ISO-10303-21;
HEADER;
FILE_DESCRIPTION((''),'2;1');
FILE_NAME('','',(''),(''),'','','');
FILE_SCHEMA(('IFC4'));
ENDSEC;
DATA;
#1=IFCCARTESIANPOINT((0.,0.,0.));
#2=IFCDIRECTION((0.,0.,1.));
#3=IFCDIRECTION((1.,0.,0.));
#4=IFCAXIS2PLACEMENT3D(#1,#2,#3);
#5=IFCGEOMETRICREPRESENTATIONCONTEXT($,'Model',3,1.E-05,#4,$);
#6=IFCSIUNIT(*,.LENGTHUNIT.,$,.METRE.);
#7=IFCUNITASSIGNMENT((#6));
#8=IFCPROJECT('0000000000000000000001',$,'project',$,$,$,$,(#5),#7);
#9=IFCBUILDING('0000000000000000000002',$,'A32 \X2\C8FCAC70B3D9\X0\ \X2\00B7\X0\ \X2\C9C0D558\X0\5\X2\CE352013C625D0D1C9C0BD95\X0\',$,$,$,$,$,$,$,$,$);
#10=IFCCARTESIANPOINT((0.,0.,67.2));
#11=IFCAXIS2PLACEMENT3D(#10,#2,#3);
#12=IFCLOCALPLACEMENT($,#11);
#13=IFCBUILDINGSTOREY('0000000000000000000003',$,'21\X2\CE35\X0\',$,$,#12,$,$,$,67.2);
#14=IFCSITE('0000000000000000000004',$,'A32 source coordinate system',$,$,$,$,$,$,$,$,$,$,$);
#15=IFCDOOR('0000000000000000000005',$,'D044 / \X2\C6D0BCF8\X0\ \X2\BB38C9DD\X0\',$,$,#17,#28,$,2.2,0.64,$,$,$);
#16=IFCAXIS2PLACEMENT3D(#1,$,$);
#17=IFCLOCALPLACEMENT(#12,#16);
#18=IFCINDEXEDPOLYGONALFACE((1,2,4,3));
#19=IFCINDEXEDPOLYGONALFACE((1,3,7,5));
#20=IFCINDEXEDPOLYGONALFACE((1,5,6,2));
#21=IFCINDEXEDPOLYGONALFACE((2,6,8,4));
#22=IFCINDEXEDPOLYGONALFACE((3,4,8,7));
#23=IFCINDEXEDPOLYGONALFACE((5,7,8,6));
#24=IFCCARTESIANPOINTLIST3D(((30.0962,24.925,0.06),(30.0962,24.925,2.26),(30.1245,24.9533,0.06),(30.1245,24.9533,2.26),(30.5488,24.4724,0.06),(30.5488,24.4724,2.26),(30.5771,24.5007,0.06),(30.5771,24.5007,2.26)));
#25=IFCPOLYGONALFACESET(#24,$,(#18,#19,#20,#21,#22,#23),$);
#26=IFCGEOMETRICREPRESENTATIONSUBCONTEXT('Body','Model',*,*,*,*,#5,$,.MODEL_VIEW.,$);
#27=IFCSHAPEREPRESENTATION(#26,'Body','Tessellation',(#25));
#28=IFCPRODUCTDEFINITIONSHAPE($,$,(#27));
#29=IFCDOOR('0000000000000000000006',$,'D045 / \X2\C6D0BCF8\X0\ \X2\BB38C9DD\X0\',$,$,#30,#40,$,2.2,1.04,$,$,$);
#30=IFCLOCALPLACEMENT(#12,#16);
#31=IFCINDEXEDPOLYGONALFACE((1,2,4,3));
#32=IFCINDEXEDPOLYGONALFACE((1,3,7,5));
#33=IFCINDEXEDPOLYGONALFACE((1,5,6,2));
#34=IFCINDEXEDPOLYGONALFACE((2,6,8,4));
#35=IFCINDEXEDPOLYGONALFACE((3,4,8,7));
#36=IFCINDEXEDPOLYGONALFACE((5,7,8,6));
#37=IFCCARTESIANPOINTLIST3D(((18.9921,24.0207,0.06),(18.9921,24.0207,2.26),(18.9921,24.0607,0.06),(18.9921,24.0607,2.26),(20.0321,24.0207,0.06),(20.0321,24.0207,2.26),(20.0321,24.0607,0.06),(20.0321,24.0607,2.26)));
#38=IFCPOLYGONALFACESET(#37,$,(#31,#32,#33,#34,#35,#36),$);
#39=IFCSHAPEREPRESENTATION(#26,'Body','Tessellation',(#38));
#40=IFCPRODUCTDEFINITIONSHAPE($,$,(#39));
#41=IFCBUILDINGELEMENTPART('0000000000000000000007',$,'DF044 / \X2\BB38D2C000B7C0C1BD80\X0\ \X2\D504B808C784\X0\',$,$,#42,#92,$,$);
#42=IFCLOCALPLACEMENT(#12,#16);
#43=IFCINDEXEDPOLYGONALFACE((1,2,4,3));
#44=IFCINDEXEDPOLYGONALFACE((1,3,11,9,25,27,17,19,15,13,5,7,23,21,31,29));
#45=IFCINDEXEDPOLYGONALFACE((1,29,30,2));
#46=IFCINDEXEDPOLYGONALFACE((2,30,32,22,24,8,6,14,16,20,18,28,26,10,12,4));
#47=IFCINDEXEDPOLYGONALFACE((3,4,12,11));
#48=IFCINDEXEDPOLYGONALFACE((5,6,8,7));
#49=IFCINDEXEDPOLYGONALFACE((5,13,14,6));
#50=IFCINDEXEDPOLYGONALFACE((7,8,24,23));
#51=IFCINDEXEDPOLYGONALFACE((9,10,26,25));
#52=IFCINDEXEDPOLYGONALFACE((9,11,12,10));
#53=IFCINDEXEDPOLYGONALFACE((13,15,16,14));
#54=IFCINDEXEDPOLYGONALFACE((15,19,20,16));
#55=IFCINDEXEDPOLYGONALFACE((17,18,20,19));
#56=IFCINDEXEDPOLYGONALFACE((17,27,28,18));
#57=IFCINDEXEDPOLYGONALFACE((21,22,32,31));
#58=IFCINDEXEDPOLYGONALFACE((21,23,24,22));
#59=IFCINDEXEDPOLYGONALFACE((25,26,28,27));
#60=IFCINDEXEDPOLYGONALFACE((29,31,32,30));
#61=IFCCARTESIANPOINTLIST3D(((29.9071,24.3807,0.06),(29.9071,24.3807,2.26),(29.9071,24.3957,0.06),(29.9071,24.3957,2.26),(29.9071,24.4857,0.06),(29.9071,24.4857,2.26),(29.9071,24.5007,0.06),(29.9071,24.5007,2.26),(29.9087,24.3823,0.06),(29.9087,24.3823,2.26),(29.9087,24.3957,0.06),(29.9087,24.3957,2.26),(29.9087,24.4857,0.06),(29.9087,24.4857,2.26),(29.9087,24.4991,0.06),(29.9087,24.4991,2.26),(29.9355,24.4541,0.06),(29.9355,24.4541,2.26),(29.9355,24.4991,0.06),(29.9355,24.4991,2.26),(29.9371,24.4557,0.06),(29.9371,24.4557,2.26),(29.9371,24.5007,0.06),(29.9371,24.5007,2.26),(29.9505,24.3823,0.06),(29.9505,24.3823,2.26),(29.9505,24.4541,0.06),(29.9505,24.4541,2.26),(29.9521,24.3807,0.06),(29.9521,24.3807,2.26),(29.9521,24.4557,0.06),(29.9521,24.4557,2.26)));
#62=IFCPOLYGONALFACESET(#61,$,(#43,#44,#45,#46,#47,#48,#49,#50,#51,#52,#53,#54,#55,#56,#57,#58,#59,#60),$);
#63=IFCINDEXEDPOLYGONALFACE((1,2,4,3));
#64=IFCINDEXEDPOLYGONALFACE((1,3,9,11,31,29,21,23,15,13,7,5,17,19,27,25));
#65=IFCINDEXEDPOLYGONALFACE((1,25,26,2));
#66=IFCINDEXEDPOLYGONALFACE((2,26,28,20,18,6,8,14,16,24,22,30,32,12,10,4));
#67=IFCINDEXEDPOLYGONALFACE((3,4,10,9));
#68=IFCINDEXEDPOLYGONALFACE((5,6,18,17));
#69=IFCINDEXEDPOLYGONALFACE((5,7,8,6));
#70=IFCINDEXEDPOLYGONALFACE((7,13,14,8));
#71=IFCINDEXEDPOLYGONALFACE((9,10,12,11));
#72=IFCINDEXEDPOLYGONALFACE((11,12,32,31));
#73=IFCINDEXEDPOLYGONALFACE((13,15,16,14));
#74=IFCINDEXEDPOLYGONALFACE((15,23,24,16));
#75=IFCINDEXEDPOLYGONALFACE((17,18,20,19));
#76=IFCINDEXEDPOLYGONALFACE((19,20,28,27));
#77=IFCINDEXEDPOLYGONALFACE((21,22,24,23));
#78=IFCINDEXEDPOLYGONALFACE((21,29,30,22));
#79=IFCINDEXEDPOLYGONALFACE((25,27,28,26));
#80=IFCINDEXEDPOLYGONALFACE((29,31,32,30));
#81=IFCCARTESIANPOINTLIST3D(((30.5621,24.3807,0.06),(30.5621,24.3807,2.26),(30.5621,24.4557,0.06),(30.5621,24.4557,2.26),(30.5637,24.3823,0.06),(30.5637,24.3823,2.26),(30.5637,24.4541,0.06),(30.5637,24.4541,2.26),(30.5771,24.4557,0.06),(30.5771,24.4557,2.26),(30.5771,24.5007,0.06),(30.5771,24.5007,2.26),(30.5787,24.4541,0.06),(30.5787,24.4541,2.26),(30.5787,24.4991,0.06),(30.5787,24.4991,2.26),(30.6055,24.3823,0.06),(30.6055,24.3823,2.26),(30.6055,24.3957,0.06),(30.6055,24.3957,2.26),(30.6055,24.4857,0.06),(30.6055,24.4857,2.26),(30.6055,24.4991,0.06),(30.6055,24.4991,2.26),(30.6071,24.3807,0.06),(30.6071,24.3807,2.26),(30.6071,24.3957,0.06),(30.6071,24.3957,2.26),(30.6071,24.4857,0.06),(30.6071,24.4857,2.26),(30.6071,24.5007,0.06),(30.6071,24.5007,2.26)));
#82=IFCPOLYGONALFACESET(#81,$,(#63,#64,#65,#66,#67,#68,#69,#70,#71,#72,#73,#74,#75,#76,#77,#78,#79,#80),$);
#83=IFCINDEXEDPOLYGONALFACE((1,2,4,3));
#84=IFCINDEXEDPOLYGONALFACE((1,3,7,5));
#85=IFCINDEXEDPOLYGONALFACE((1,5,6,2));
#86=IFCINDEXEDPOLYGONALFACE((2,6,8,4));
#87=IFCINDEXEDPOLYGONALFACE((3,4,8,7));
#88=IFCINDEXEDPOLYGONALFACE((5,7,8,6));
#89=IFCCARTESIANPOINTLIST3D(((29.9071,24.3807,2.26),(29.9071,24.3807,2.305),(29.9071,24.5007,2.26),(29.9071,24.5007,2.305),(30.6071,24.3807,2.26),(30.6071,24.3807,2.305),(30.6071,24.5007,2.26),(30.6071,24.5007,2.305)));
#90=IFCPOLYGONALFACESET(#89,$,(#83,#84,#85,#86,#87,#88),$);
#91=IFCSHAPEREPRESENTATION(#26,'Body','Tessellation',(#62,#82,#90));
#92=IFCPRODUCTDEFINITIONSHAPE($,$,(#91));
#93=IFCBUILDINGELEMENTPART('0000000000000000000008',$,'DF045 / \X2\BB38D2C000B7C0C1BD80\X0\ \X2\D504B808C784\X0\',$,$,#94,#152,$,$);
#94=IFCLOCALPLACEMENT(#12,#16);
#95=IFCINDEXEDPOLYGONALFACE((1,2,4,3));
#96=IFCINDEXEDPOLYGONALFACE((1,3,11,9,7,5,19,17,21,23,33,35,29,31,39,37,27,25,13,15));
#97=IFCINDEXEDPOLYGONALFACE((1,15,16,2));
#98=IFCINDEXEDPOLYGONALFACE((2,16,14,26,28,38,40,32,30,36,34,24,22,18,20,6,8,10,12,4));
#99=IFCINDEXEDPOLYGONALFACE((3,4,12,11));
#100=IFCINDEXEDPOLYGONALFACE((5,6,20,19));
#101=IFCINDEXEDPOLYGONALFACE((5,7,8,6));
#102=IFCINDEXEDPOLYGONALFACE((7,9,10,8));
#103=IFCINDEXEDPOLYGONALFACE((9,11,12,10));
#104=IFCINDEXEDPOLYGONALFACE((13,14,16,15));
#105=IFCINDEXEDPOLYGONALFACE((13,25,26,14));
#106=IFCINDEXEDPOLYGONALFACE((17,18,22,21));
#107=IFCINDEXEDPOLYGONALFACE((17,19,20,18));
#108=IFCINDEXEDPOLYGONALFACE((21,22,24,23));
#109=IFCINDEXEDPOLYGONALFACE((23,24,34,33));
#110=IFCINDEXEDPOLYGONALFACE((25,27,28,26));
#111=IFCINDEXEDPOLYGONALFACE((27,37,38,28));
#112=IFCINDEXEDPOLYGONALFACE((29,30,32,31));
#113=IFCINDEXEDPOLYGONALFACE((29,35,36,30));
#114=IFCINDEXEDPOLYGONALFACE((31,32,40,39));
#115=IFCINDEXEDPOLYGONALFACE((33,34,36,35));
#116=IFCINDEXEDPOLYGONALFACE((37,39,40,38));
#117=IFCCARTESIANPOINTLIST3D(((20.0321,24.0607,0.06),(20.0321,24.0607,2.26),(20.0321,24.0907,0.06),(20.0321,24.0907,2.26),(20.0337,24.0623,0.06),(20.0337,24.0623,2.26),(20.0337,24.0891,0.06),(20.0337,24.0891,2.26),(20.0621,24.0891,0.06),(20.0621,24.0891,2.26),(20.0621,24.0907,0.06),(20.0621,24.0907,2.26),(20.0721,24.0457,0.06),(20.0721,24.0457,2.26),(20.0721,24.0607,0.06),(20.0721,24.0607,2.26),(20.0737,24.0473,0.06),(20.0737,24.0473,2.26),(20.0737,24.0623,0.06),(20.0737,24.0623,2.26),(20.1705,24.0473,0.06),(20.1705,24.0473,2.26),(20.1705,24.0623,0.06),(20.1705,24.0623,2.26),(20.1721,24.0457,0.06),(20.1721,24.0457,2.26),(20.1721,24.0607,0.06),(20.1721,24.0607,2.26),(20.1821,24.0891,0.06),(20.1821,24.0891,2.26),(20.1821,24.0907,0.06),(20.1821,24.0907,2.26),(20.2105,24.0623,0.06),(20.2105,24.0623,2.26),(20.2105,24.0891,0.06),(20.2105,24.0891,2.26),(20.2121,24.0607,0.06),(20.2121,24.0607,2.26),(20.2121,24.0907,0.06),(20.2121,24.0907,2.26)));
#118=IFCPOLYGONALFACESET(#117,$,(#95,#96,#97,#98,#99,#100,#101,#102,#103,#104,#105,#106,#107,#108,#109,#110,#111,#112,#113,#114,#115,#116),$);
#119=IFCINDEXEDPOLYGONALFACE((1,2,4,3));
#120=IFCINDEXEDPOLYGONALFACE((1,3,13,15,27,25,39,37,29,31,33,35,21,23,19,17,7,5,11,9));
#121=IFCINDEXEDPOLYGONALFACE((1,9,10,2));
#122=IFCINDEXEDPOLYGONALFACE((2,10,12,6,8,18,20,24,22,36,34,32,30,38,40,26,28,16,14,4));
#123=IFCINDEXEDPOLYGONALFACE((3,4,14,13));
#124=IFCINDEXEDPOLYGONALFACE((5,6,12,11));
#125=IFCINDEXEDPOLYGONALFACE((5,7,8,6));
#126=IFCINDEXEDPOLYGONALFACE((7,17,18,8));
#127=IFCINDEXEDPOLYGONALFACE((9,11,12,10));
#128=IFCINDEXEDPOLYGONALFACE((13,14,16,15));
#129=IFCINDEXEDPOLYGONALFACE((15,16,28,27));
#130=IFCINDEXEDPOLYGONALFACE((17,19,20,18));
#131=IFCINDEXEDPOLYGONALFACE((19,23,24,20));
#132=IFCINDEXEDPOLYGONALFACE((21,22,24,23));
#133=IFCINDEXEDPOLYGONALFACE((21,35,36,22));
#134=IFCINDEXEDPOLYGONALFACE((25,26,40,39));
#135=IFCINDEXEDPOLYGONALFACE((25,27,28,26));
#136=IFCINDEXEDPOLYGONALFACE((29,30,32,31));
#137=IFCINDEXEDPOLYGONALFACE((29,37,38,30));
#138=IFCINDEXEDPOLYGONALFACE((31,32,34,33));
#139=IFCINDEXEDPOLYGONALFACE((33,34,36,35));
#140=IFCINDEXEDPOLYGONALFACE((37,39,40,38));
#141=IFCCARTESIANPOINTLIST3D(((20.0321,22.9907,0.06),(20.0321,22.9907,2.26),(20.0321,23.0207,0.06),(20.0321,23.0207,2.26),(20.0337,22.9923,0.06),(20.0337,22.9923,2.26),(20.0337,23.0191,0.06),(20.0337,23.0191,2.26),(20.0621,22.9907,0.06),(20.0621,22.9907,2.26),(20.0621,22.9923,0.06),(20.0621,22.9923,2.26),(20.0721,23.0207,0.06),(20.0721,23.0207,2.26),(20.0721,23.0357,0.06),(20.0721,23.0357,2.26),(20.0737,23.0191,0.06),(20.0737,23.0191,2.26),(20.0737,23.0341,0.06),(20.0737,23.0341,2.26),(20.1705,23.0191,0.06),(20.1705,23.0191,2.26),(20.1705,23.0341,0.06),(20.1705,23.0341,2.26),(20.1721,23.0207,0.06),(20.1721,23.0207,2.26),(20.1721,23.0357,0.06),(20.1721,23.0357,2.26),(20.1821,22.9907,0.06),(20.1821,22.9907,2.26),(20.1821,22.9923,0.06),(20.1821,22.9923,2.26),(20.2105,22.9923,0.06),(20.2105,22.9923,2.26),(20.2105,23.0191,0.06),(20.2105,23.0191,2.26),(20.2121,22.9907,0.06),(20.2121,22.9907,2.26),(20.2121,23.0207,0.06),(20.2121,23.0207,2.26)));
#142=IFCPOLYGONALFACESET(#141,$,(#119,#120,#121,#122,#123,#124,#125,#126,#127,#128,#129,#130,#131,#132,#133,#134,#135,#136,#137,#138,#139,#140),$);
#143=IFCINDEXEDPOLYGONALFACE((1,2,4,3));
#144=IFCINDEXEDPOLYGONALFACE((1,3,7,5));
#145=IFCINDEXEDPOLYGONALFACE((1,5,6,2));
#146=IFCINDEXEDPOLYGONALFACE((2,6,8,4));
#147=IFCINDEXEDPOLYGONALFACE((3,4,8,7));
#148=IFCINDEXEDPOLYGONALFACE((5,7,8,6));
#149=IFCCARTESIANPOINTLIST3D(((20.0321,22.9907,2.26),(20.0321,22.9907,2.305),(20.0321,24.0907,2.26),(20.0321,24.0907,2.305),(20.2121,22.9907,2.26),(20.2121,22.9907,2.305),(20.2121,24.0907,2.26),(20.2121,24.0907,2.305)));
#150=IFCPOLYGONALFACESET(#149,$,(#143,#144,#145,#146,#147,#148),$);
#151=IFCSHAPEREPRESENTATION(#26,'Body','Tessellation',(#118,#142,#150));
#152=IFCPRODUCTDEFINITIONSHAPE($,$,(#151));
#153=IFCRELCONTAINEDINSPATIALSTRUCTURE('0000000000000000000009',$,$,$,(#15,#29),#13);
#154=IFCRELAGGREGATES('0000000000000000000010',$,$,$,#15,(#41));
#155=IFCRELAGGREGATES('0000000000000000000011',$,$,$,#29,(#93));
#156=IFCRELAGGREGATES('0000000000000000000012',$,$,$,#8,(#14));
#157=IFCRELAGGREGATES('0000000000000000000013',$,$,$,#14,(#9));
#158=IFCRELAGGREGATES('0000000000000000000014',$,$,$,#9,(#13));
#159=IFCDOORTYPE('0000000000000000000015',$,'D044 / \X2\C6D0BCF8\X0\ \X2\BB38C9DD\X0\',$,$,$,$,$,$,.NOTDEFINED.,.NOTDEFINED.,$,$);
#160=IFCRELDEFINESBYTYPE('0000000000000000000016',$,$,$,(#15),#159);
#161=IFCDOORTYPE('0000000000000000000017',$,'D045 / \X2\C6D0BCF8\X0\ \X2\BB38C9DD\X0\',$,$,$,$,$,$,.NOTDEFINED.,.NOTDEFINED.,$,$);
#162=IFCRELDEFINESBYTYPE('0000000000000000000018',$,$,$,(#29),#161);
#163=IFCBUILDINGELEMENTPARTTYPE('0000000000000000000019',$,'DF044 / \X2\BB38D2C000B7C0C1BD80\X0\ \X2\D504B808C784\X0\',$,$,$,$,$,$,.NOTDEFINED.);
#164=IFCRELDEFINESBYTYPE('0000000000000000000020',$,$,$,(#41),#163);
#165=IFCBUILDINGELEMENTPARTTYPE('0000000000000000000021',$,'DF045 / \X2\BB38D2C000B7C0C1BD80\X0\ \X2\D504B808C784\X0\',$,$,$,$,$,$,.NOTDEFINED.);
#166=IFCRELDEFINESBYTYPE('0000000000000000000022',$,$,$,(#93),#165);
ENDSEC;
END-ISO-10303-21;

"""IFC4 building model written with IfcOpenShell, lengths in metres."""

from ifc_helpers import new_model, si_unit, frame, origin, origin_with_axes, place, context, subcontext, project, spatial, polyline, outline, extrude, source, transform, mapped, type_object, type_shapes, element, aggregate, save


model = new_model("IFC4")

# Units and contexts
model_context = context("Model", 3, precision=1e-05, world=origin_with_axes())
body_context = subcontext(model_context, "Body", "Model", "MODEL_VIEW")
ifc_project = project(units=[si_unit("LENGTHUNIT", "METRE")], contexts=[model_context])

# Site, building, storey
storey_placement = place(None, frame((0.0, 0.0, 67.2), z_axis=(0.0, 0.0, 1.0), x_axis=(1.0, 0.0, 0.0)))
site = spatial("IfcSite", under=ifc_project, Name="A32 source coordinate system")
building = spatial("IfcBuilding", under=site, Name="A32 주거동 · 지하5층–옥탑지붕")
storey = spatial("IfcBuildingStorey", under=building, at=storey_placement, Name="21층", Elevation=67.2)

# Doors
door_type_1 = type_object("IfcDoorType", Name="D044 / 원본 문짝", OperationType="NOTDEFINED", PredefinedType="NOTDEFINED")
shared_shape_1 = source(origin(), body_context, "Body", "SweptSolid", [
    extrude(outline(polyline([(30.5771, 24.5007), (30.5488, 24.4724), (30.0962, 24.925), (30.1245, 24.9533), (30.5771, 24.5007)])), frame((0.0, 0.0, 0.06)), (0.0, 0.0, 1.0), 2.2),
])
type_shapes(door_type_1, [shared_shape_1])
door_1_placement = place(storey_placement, origin_with_axes())
door_1 = element("IfcDoor", 1, at=door_1_placement, inside=storey, type_object=door_type_1, Name="D044 / 원본 문짝", OverallHeight=2.2, OverallWidth=0.64, context=body_context, shape_type="MappedRepresentation", body=[
    mapped(shared_shape_1, transform((0.0, 0.0, 0.0), scale=1.0)),
])
door_type_2 = type_object("IfcDoorType", Name="D045 / 원본 문짝", OperationType="NOTDEFINED", PredefinedType="NOTDEFINED")
shared_shape_2 = source(origin(), body_context, "Body", "SweptSolid", [
    extrude(outline(polyline([(20.0321, 24.0607), (20.0321, 24.0207), (18.9921, 24.0207), (18.9921, 24.0607), (20.0321, 24.0607)])), frame((0.0, 0.0, 0.06)), (0.0, 0.0, 1.0), 2.2),
])
type_shapes(door_type_2, [shared_shape_2])
door_2_placement = place(storey_placement, origin_with_axes())
door_2 = element("IfcDoor", 2, at=door_2_placement, inside=storey, type_object=door_type_2, Name="D045 / 원본 문짝", OverallHeight=2.2, OverallWidth=1.04, context=body_context, shape_type="MappedRepresentation", body=[
    mapped(shared_shape_2, transform((0.0, 0.0, 0.0), scale=1.0)),
])

# Building element parts
building_element_part_type_1 = type_object("IfcBuildingElementPartType", Name="DF044 / 문틀·상부 프레임", PredefinedType="NOTDEFINED")
shared_shape_3 = source(origin(), body_context, "Body", "SweptSolid", [
    extrude(outline(polyline([(29.9071, 24.4857), (29.9071, 24.5007), (29.9371, 24.5007), (29.9371, 24.4557), (29.9521, 24.4557), (29.9521, 24.3807), (29.9071, 24.3807), (29.9071, 24.3957), (29.9087, 24.3957), (29.9087, 24.3823), (29.9505, 24.3823), (29.9505, 24.4541), (29.9355, 24.4541), (29.9355, 24.4991), (29.9087, 24.4991), (29.9087, 24.4857), (29.9071, 24.4857)])), frame((0.0, 0.0, 0.06)), (0.0, 0.0, 1.0), 2.2),
    extrude(outline(polyline([(30.6055, 24.4991), (30.5787, 24.4991), (30.5787, 24.4541), (30.5637, 24.4541), (30.5637, 24.3823), (30.6055, 24.3823), (30.6055, 24.3957), (30.6071, 24.3957), (30.6071, 24.3807), (30.5621, 24.3807), (30.5621, 24.4557), (30.5771, 24.4557), (30.5771, 24.5007), (30.6071, 24.5007), (30.6071, 24.4857), (30.6055, 24.4857), (30.6055, 24.4991)])), frame((0.0, 0.0, 0.06)), (0.0, 0.0, 1.0), 2.2),
    extrude(outline(polyline([(29.9071, 24.3807), (29.9071, 24.5007), (30.6071, 24.5007), (30.6071, 24.3807), (29.9071, 24.3807)])), frame((0.0, 0.0, 2.26)), (0.0, 0.0, 1.0), 0.045),
])
type_shapes(building_element_part_type_1, [shared_shape_3])
building_element_part_1_placement = place(door_1_placement, origin_with_axes())
building_element_part_1 = element("IfcBuildingElementPart", 3, at=building_element_part_1_placement, type_object=building_element_part_type_1, Name="DF044 / 문틀·상부 프레임", context=body_context, shape_type="MappedRepresentation", body=[
    mapped(shared_shape_3, transform((0.0, 0.0, 0.0), scale=1.0)),
])
aggregate(door_1, [building_element_part_1])
building_element_part_type_2 = type_object("IfcBuildingElementPartType", Name="DF045 / 문틀·상부 프레임", PredefinedType="NOTDEFINED")
shared_shape_4 = source(origin(), body_context, "Body", "SweptSolid", [
    extrude(outline(polyline([(20.0337, 24.0891), (20.0337, 24.0623), (20.0737, 24.0623), (20.0737, 24.0473), (20.1705, 24.0473), (20.1705, 24.0623), (20.2105, 24.0623), (20.2105, 24.0891), (20.1821, 24.0891), (20.1821, 24.0907), (20.2121, 24.0907), (20.2121, 24.0607), (20.1721, 24.0607), (20.1721, 24.0457), (20.0721, 24.0457), (20.0721, 24.0607), (20.0321, 24.0607), (20.0321, 24.0907), (20.0621, 24.0907), (20.0621, 24.0891), (20.0337, 24.0891)])), frame((0.0, 0.0, 0.06)), (0.0, 0.0, 1.0), 2.2),
    extrude(outline(polyline([(20.0621, 22.9907), (20.0321, 22.9907), (20.0321, 23.0207), (20.0721, 23.0207), (20.0721, 23.0357), (20.1721, 23.0357), (20.1721, 23.0207), (20.2121, 23.0207), (20.2121, 22.9907), (20.1821, 22.9907), (20.1821, 22.9923), (20.2105, 22.9923), (20.2105, 23.0191), (20.1705, 23.0191), (20.1705, 23.0341), (20.0737, 23.0341), (20.0737, 23.0191), (20.0337, 23.0191), (20.0337, 22.9923), (20.0621, 22.9923), (20.0621, 22.9907)])), frame((0.0, 0.0, 0.06)), (0.0, 0.0, 1.0), 2.2),
    extrude(outline(polyline([(20.0321, 22.9907), (20.0321, 24.0907), (20.2121, 24.0907), (20.2121, 22.9907), (20.0321, 22.9907)])), frame((0.0, 0.0, 2.26)), (0.0, 0.0, 1.0), 0.045),
])
type_shapes(building_element_part_type_2, [shared_shape_4])
building_element_part_2_placement = place(door_2_placement, origin_with_axes())
building_element_part_2 = element("IfcBuildingElementPart", 4, at=building_element_part_2_placement, type_object=building_element_part_type_2, Name="DF045 / 문틀·상부 프레임", context=body_context, shape_type="MappedRepresentation", body=[
    mapped(shared_shape_4, transform((0.0, 0.0, 0.0), scale=1.0)),
])
aggregate(door_2, [building_element_part_2])

save(model, "model.ifc")
